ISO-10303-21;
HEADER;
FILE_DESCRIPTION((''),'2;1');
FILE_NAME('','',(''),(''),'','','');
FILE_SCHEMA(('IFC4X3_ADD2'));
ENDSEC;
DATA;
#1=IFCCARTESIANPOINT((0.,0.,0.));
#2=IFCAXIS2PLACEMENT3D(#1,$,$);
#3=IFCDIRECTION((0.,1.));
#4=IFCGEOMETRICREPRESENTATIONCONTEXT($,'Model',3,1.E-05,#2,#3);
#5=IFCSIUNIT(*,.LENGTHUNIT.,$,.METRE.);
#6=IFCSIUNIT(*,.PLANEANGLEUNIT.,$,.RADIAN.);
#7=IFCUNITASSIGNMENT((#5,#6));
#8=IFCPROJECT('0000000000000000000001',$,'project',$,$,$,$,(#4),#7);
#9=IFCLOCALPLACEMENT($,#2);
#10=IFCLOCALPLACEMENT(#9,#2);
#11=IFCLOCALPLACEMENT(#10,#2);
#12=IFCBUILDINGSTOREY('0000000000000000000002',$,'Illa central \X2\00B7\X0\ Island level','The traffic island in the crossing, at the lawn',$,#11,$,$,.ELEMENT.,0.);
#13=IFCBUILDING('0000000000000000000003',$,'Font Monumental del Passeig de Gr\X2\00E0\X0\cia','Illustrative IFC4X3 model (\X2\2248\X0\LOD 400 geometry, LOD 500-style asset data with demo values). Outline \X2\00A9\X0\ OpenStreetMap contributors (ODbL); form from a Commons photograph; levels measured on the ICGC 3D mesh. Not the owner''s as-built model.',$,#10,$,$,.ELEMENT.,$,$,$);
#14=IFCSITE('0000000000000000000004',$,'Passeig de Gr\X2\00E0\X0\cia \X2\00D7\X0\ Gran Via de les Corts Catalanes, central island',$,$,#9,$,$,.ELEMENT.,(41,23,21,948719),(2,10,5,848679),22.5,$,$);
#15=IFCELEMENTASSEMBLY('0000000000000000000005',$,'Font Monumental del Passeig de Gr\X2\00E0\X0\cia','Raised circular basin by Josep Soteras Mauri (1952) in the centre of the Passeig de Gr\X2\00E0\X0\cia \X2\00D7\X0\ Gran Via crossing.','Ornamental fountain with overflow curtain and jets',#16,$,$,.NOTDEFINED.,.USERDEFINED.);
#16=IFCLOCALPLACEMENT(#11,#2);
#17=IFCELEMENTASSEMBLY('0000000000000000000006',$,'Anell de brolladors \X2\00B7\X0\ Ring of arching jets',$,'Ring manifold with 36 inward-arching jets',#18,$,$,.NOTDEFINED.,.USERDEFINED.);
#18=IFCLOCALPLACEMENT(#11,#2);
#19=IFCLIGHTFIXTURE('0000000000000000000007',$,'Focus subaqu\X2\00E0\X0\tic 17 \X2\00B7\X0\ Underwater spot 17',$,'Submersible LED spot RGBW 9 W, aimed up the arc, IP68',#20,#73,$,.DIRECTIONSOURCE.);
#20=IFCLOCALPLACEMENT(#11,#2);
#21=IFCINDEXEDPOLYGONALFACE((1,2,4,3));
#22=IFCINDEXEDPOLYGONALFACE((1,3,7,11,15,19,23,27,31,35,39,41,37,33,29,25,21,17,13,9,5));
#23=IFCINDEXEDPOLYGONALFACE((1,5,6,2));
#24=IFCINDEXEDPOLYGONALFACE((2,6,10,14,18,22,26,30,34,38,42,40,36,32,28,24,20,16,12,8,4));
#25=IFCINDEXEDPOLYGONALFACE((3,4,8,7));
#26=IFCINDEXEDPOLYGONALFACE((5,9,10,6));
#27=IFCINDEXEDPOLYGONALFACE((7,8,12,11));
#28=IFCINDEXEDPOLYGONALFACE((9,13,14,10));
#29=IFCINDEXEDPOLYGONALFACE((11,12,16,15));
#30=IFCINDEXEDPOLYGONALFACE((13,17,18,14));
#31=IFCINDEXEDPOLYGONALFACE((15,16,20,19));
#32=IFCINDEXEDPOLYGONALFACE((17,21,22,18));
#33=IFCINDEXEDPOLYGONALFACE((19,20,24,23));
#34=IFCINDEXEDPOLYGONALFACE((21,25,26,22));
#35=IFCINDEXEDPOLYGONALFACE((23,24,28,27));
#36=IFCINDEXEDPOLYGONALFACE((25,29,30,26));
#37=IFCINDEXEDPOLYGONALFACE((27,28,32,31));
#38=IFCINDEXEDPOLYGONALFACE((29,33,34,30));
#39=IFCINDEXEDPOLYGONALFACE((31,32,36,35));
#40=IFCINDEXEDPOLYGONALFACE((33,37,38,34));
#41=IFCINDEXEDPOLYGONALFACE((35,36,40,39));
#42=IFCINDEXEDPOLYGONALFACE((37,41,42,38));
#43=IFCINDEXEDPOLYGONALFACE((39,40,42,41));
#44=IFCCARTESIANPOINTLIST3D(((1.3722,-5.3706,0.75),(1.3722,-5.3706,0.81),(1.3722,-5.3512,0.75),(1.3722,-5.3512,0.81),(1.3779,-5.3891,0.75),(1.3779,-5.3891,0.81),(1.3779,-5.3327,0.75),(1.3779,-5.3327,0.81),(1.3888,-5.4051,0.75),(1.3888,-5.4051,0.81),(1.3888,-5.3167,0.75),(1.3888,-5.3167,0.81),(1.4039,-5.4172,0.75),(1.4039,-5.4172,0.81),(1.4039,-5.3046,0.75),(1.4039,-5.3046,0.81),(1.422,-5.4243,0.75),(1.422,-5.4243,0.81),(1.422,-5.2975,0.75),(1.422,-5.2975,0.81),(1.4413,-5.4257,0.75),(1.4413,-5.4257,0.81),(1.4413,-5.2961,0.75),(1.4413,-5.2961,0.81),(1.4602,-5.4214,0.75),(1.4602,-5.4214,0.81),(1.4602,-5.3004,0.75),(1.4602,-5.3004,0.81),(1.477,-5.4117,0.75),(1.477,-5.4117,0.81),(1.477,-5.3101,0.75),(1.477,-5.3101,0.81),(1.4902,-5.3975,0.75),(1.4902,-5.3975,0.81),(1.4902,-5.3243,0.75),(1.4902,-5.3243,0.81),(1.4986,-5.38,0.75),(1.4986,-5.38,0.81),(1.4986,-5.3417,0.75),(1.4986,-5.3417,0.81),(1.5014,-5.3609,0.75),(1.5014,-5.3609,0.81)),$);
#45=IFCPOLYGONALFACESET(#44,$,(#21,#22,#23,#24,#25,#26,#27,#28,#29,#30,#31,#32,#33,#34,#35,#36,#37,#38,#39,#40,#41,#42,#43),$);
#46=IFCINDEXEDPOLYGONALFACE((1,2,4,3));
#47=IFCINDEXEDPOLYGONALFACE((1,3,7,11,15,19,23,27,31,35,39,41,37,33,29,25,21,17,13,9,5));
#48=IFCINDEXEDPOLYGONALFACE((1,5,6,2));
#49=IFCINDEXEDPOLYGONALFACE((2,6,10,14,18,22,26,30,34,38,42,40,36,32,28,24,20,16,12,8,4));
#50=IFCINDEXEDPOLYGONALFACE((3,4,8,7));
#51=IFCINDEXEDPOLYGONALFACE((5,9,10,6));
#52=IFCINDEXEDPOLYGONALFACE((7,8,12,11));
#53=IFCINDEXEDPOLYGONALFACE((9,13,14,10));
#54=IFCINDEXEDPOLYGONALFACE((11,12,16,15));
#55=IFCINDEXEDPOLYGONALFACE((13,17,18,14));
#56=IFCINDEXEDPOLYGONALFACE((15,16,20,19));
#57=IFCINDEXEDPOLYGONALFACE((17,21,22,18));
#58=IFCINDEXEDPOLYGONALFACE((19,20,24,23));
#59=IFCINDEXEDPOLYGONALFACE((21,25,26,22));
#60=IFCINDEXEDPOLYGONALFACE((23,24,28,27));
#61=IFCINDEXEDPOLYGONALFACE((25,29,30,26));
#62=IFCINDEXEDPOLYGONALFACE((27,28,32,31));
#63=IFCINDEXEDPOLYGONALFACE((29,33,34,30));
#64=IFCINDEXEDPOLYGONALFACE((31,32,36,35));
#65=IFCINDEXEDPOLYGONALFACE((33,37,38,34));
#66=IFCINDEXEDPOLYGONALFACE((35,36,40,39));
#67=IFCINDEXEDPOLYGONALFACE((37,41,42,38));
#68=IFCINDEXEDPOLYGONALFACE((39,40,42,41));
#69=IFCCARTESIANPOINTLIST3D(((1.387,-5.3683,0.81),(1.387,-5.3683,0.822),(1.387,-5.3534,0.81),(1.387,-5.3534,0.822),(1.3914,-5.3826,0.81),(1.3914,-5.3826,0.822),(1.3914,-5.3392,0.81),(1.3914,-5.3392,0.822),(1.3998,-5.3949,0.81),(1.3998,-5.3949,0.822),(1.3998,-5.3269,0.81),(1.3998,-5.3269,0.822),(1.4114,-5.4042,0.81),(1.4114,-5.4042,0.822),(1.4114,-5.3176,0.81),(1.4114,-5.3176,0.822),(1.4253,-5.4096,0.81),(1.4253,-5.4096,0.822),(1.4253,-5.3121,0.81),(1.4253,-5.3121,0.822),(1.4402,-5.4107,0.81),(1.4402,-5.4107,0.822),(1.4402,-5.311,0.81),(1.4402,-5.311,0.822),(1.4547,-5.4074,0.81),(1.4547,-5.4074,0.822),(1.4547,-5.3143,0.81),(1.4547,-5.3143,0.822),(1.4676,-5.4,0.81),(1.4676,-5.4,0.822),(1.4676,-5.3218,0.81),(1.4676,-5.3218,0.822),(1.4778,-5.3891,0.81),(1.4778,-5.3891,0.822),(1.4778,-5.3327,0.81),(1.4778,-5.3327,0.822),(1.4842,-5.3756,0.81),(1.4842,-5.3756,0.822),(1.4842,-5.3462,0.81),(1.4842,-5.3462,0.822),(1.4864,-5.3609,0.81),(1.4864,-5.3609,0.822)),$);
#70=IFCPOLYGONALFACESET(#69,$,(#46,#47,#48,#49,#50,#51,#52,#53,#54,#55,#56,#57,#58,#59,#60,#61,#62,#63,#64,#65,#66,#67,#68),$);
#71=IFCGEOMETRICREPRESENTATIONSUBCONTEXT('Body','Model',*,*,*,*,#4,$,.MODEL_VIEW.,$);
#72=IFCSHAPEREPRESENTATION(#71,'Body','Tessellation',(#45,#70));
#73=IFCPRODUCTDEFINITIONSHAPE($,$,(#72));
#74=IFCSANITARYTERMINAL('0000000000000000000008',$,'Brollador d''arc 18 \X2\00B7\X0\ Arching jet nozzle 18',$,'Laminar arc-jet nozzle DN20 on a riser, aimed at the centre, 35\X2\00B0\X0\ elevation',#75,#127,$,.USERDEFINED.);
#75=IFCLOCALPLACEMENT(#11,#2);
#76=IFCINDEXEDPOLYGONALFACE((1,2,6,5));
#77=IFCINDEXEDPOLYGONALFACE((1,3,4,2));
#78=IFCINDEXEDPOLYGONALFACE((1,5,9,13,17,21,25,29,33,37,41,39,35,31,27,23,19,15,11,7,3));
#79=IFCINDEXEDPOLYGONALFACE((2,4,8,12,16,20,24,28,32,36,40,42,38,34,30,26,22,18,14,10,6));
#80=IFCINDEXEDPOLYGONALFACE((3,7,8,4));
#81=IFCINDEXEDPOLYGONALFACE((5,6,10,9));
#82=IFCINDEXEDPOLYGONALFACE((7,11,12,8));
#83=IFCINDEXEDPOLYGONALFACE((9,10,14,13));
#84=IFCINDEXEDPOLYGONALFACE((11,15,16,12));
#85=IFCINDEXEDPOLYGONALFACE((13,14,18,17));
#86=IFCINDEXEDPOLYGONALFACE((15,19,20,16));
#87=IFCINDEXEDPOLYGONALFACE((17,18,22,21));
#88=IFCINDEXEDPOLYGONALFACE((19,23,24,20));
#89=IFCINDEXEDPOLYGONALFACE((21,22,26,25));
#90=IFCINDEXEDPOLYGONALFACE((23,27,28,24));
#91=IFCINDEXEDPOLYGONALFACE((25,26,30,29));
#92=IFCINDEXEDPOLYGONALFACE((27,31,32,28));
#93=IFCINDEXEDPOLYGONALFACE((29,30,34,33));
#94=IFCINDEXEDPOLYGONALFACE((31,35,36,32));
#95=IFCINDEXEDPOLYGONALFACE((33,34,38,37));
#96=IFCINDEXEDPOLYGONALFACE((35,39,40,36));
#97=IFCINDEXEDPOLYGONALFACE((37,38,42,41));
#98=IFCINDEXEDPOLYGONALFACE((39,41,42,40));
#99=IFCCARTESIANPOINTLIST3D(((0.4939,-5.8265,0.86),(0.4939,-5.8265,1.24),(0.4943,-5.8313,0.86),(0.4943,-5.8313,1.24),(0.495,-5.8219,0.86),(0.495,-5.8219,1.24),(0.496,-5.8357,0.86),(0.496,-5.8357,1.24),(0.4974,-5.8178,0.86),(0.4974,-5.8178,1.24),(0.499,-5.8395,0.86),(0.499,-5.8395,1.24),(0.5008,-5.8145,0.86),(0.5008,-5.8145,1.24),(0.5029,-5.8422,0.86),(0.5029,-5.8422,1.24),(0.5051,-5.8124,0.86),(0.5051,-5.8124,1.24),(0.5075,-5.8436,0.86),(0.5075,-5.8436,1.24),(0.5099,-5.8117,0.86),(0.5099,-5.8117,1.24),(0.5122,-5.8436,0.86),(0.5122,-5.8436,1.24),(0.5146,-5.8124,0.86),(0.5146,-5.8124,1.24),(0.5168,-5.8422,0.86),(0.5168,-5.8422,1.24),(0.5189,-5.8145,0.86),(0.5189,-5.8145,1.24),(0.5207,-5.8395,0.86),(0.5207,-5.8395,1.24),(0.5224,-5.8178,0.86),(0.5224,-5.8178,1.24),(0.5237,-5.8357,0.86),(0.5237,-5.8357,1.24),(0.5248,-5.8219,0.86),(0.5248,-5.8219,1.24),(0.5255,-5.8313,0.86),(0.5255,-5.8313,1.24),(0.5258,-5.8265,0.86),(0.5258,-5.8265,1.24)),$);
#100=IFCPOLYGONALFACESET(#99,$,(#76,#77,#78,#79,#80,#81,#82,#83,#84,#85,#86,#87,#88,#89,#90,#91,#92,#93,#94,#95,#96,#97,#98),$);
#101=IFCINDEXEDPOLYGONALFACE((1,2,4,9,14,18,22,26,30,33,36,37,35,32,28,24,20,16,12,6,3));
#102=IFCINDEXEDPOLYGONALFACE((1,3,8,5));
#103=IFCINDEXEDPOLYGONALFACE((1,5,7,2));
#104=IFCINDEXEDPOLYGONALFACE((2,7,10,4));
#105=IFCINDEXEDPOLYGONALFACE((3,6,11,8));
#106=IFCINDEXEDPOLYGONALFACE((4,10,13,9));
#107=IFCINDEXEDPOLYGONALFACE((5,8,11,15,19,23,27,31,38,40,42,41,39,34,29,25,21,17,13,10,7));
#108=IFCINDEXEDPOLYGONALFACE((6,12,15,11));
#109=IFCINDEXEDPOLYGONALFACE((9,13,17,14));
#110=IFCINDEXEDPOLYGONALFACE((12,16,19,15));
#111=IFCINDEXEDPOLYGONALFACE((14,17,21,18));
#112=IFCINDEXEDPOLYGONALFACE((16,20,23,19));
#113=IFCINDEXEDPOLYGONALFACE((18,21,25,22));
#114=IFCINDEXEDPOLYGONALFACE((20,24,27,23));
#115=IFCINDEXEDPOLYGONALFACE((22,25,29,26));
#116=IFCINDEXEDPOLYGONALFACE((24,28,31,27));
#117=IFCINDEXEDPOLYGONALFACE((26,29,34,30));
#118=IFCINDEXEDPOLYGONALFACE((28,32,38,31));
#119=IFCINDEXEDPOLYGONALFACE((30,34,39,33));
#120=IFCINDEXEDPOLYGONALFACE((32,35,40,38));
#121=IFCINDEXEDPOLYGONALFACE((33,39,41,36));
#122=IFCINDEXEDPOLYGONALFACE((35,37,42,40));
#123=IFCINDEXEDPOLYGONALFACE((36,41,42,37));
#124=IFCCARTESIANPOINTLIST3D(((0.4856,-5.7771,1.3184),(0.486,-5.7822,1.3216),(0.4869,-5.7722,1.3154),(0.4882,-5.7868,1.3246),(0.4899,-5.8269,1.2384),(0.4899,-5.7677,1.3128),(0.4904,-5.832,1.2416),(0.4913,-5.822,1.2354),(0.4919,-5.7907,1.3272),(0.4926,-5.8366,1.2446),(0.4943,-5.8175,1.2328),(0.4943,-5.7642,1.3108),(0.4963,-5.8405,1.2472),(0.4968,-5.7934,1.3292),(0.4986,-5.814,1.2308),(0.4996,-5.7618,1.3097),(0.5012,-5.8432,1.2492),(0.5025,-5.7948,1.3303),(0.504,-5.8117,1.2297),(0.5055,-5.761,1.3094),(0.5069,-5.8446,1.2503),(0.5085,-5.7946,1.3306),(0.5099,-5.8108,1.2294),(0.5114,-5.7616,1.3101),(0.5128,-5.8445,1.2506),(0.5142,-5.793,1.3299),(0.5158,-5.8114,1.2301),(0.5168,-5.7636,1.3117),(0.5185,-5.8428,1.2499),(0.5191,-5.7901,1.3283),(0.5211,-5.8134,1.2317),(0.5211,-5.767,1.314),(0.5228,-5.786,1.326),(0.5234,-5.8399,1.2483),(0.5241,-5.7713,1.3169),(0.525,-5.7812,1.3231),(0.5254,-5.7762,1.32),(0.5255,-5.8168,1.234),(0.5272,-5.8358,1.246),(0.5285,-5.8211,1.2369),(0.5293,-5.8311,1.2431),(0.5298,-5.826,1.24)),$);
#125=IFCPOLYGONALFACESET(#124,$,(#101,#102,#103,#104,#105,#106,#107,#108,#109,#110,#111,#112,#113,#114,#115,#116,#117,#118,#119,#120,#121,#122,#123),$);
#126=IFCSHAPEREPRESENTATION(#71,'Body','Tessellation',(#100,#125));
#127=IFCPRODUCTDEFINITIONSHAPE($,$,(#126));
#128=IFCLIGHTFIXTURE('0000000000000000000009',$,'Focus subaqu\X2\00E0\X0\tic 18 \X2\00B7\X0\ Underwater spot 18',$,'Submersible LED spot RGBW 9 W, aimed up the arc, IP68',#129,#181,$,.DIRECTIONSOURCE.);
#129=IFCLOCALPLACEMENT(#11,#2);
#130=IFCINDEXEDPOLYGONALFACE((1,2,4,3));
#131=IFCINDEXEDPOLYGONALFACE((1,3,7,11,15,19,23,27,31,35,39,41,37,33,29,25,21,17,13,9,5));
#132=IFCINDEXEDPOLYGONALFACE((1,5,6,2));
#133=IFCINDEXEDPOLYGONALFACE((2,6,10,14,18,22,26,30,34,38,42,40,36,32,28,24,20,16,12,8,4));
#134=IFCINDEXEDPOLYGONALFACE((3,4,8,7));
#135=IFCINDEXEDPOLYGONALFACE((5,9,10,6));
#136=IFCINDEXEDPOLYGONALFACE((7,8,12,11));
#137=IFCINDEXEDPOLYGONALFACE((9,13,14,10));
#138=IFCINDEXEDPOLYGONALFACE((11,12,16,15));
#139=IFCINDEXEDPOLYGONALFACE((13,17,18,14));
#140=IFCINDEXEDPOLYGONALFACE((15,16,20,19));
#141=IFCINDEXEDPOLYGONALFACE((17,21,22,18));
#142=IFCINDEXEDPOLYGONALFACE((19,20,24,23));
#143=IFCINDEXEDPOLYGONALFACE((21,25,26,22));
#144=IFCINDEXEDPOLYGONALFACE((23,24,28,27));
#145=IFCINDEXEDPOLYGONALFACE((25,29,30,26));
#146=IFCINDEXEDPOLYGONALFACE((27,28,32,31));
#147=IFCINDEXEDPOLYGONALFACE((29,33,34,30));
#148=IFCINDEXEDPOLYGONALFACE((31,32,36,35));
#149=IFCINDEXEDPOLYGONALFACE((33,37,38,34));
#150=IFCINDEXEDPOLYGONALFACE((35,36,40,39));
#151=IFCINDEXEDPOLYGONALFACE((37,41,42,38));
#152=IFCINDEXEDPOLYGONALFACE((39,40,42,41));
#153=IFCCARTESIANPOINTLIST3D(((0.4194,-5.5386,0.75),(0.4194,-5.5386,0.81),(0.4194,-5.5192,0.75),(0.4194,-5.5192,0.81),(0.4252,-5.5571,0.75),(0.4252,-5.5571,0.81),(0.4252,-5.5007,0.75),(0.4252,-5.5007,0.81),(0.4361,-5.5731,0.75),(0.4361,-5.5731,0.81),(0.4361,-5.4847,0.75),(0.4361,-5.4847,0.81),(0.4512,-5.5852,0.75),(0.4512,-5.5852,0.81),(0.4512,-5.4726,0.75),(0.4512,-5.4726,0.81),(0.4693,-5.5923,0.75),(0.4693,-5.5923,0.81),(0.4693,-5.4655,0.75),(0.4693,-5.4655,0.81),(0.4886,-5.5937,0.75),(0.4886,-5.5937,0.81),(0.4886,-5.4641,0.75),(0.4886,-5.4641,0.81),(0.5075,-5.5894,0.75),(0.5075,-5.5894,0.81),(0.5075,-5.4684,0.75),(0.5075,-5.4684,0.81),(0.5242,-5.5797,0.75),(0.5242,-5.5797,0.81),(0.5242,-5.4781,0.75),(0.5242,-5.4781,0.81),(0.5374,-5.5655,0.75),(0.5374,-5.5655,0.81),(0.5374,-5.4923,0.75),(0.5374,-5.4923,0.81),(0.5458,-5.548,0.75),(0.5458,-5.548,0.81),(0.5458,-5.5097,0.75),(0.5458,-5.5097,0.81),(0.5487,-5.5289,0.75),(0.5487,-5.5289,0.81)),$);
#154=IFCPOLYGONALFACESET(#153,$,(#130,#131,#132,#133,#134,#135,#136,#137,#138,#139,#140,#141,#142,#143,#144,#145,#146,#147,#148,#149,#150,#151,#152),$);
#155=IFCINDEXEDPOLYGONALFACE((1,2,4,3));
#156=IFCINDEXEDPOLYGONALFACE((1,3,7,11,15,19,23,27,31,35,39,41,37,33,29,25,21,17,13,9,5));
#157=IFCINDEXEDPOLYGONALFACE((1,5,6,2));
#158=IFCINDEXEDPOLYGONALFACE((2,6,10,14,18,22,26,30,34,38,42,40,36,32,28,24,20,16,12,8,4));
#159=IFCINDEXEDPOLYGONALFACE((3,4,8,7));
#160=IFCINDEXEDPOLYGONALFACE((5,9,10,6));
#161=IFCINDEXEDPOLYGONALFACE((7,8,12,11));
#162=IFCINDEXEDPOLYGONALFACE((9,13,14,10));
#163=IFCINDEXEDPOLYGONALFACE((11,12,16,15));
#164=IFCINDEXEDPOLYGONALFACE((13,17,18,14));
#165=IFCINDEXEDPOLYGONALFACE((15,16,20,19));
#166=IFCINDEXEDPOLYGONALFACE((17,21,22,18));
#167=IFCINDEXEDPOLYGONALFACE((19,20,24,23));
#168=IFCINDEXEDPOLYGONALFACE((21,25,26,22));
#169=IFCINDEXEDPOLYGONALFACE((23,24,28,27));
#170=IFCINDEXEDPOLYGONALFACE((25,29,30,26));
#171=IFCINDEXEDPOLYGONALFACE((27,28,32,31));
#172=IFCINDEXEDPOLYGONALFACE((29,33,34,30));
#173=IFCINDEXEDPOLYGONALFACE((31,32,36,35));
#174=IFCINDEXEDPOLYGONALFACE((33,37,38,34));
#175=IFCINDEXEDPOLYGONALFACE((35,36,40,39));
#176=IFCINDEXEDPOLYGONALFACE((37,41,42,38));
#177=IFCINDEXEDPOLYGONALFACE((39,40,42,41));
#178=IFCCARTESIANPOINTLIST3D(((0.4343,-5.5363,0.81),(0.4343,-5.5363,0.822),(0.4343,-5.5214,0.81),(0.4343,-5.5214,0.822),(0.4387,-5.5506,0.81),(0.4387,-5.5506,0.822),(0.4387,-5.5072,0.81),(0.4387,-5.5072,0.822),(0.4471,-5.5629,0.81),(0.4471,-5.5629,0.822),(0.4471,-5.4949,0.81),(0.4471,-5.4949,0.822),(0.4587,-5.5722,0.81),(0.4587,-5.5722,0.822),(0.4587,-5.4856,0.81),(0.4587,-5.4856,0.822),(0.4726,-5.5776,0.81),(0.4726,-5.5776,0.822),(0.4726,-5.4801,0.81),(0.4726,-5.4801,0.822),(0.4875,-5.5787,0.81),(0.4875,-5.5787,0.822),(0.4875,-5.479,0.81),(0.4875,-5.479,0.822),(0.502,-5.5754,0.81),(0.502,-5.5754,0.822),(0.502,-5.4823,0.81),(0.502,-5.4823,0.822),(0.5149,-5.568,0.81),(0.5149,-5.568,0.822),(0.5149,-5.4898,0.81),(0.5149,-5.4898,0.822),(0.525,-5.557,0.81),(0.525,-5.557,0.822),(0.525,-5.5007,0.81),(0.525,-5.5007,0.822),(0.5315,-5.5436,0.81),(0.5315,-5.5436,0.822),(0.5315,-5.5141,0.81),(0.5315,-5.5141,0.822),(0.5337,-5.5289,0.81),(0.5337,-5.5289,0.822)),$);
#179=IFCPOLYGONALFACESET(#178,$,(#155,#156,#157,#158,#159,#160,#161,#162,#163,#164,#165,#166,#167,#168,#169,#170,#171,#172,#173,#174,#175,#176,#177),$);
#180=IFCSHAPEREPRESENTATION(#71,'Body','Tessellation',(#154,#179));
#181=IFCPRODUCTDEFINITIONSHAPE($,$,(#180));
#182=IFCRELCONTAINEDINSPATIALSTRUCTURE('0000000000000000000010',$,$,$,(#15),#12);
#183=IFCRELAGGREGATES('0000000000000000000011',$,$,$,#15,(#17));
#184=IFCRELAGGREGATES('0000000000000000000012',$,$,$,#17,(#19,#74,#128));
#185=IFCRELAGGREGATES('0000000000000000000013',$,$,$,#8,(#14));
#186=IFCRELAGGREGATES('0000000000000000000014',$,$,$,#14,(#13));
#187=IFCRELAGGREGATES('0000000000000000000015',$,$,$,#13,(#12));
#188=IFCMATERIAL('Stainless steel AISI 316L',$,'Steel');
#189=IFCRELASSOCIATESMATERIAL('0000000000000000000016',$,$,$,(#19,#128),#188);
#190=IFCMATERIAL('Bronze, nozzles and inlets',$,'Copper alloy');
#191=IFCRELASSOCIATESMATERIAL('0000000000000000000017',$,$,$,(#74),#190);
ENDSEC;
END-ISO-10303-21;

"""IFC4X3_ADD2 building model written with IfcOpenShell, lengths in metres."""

from ifc_helpers import new_model, si_unit, direction, frame, origin, origin_2d_with_axis, place, context, subcontext, project, spatial, circle, extrude, material, element, aggregate, save


model = new_model("IFC4X3_ADD2")

# Units and contexts
model_context = context("Model", 3, precision=1e-05, world=origin(), true_north=direction((0.0, 1.0)))
body_context = subcontext(model_context, "Body", "Model", "MODEL_VIEW")
ifc_project = project(units=[si_unit("LENGTHUNIT", "METRE"), si_unit("PLANEANGLEUNIT", "RADIAN")], contexts=[model_context])

# Site, building, storey
site_placement = place(None, origin())
site = spatial("IfcSite", under=ifc_project, at=site_placement, Name="Passeig de Gràcia × Gran Via de les Corts Catalanes, central island", CompositionType="ELEMENT", RefLatitude=(41, 23, 21, 948719), RefLongitude=(2, 10, 5, 848679), RefElevation=22.5)
building_placement = place(site_placement, origin())
building = spatial("IfcBuilding", under=site, at=building_placement, Name="Font Monumental del Passeig de Gràcia", Description="Illustrative IFC4X3 model (≈LOD 400 geometry, LOD 500-style asset data with demo values). Outline © OpenStreetMap contributors (ODbL); form from a Commons photograph; levels measured on the ICGC 3D mesh. Not the owner's as-built model.", CompositionType="ELEMENT")
storey_placement = place(building_placement, origin())
storey = spatial("IfcBuildingStorey", under=building, at=storey_placement, Name="Illa central · Island level", Description="The traffic island in the crossing, at the lawn", CompositionType="ELEMENT", Elevation=0.0)

# Element assemblies, light fixtures, sanitary terminal
assembly_1_placement = place(building_placement, origin())
assembly_1 = element("IfcElementAssembly", 1, at=assembly_1_placement, inside=storey, Name="Font Monumental del Passeig de Gràcia", Description="Raised circular basin by Josep Soteras Mauri (1952) in the centre of the Passeig de Gràcia × Gran Via crossing.", ObjectType="Ornamental fountain with overflow curtain and jets", AssemblyPlace="NOTDEFINED", PredefinedType="USERDEFINED")
assembly_2_placement = place(building_placement, origin())
assembly_2 = element("IfcElementAssembly", 2, at=assembly_2_placement, Name="Anell de brolladors · Ring of arching jets", ObjectType="Ring manifold with 36 inward-arching jets", AssemblyPlace="NOTDEFINED", PredefinedType="USERDEFINED")
aggregate(assembly_1, [assembly_2])
ifc_material_1 = material(Name="Bronze, nozzles and inlets", Category="Copper alloy")
ifc_material_2 = material(Name="Stainless steel AISI 316L", Category="Steel")
light_fixture_1_placement = place(building_placement, origin())
light_fixture_1 = element("IfcLightFixture", 3, at=light_fixture_1_placement, material=ifc_material_2, Name="Focus subaquàtic 17 · Underwater spot 17", ObjectType="Submersible LED spot RGBW 9 W, aimed up the arc, IP68", PredefinedType="DIRECTIONSOURCE", context=body_context, shape_type="SweptSolid", body=[
    extrude(circle(Radius=0.065, at=origin_2d_with_axis()), frame((1.4364, -5.3609, 0.75)), (0.0, 0.0, 1.0), 0.06),
    extrude(circle(Radius=0.05, at=origin_2d_with_axis()), frame((1.4364, -5.3609, 0.81)), (0.0, 0.0, 1.0), 0.012),
])
sanitary_terminal_1_placement = place(building_placement, origin())
sanitary_terminal_1 = element("IfcSanitaryTerminal", 4, at=sanitary_terminal_1_placement, material=ifc_material_1, Name="Brollador d'arc 18 · Arching jet nozzle 18", ObjectType="Laminar arc-jet nozzle DN20 on a riser, aimed at the centre, 35° elevation", PredefinedType="USERDEFINED", context=body_context, shape_type="SweptSolid", body=[
    extrude(circle(Radius=0.016, at=origin_2d_with_axis()), frame((0.5099, -5.8277, 0.86), z_axis=(0.0, 0.0, 1.0), x_axis=(0.0, 1.0, 0.0)), (0.0, 0.0, 1.0), 0.38),
    extrude(circle(Radius=0.02, at=origin_2d_with_axis()), frame((0.5099, -5.8277, 1.24), z_axis=(-0.046192, 0.527982, 0.847998), x_axis=(0.996195, 0.087156, 0.0)), (0.0, 0.0, 1.0), 0.0943),
])
light_fixture_2_placement = place(building_placement, origin())
light_fixture_2 = element("IfcLightFixture", 5, at=light_fixture_2_placement, material=ifc_material_2, Name="Focus subaquàtic 18 · Underwater spot 18", ObjectType="Submersible LED spot RGBW 9 W, aimed up the arc, IP68", PredefinedType="DIRECTIONSOURCE", context=body_context, shape_type="SweptSolid", body=[
    extrude(circle(Radius=0.065, at=origin_2d_with_axis()), frame((0.4837, -5.5289, 0.75)), (0.0, 0.0, 1.0), 0.06),
    extrude(circle(Radius=0.05, at=origin_2d_with_axis()), frame((0.4837, -5.5289, 0.81)), (0.0, 0.0, 1.0), 0.012),
])
aggregate(assembly_2, [light_fixture_1, sanitary_terminal_1, light_fixture_2])

save(model, "model.ifc")
